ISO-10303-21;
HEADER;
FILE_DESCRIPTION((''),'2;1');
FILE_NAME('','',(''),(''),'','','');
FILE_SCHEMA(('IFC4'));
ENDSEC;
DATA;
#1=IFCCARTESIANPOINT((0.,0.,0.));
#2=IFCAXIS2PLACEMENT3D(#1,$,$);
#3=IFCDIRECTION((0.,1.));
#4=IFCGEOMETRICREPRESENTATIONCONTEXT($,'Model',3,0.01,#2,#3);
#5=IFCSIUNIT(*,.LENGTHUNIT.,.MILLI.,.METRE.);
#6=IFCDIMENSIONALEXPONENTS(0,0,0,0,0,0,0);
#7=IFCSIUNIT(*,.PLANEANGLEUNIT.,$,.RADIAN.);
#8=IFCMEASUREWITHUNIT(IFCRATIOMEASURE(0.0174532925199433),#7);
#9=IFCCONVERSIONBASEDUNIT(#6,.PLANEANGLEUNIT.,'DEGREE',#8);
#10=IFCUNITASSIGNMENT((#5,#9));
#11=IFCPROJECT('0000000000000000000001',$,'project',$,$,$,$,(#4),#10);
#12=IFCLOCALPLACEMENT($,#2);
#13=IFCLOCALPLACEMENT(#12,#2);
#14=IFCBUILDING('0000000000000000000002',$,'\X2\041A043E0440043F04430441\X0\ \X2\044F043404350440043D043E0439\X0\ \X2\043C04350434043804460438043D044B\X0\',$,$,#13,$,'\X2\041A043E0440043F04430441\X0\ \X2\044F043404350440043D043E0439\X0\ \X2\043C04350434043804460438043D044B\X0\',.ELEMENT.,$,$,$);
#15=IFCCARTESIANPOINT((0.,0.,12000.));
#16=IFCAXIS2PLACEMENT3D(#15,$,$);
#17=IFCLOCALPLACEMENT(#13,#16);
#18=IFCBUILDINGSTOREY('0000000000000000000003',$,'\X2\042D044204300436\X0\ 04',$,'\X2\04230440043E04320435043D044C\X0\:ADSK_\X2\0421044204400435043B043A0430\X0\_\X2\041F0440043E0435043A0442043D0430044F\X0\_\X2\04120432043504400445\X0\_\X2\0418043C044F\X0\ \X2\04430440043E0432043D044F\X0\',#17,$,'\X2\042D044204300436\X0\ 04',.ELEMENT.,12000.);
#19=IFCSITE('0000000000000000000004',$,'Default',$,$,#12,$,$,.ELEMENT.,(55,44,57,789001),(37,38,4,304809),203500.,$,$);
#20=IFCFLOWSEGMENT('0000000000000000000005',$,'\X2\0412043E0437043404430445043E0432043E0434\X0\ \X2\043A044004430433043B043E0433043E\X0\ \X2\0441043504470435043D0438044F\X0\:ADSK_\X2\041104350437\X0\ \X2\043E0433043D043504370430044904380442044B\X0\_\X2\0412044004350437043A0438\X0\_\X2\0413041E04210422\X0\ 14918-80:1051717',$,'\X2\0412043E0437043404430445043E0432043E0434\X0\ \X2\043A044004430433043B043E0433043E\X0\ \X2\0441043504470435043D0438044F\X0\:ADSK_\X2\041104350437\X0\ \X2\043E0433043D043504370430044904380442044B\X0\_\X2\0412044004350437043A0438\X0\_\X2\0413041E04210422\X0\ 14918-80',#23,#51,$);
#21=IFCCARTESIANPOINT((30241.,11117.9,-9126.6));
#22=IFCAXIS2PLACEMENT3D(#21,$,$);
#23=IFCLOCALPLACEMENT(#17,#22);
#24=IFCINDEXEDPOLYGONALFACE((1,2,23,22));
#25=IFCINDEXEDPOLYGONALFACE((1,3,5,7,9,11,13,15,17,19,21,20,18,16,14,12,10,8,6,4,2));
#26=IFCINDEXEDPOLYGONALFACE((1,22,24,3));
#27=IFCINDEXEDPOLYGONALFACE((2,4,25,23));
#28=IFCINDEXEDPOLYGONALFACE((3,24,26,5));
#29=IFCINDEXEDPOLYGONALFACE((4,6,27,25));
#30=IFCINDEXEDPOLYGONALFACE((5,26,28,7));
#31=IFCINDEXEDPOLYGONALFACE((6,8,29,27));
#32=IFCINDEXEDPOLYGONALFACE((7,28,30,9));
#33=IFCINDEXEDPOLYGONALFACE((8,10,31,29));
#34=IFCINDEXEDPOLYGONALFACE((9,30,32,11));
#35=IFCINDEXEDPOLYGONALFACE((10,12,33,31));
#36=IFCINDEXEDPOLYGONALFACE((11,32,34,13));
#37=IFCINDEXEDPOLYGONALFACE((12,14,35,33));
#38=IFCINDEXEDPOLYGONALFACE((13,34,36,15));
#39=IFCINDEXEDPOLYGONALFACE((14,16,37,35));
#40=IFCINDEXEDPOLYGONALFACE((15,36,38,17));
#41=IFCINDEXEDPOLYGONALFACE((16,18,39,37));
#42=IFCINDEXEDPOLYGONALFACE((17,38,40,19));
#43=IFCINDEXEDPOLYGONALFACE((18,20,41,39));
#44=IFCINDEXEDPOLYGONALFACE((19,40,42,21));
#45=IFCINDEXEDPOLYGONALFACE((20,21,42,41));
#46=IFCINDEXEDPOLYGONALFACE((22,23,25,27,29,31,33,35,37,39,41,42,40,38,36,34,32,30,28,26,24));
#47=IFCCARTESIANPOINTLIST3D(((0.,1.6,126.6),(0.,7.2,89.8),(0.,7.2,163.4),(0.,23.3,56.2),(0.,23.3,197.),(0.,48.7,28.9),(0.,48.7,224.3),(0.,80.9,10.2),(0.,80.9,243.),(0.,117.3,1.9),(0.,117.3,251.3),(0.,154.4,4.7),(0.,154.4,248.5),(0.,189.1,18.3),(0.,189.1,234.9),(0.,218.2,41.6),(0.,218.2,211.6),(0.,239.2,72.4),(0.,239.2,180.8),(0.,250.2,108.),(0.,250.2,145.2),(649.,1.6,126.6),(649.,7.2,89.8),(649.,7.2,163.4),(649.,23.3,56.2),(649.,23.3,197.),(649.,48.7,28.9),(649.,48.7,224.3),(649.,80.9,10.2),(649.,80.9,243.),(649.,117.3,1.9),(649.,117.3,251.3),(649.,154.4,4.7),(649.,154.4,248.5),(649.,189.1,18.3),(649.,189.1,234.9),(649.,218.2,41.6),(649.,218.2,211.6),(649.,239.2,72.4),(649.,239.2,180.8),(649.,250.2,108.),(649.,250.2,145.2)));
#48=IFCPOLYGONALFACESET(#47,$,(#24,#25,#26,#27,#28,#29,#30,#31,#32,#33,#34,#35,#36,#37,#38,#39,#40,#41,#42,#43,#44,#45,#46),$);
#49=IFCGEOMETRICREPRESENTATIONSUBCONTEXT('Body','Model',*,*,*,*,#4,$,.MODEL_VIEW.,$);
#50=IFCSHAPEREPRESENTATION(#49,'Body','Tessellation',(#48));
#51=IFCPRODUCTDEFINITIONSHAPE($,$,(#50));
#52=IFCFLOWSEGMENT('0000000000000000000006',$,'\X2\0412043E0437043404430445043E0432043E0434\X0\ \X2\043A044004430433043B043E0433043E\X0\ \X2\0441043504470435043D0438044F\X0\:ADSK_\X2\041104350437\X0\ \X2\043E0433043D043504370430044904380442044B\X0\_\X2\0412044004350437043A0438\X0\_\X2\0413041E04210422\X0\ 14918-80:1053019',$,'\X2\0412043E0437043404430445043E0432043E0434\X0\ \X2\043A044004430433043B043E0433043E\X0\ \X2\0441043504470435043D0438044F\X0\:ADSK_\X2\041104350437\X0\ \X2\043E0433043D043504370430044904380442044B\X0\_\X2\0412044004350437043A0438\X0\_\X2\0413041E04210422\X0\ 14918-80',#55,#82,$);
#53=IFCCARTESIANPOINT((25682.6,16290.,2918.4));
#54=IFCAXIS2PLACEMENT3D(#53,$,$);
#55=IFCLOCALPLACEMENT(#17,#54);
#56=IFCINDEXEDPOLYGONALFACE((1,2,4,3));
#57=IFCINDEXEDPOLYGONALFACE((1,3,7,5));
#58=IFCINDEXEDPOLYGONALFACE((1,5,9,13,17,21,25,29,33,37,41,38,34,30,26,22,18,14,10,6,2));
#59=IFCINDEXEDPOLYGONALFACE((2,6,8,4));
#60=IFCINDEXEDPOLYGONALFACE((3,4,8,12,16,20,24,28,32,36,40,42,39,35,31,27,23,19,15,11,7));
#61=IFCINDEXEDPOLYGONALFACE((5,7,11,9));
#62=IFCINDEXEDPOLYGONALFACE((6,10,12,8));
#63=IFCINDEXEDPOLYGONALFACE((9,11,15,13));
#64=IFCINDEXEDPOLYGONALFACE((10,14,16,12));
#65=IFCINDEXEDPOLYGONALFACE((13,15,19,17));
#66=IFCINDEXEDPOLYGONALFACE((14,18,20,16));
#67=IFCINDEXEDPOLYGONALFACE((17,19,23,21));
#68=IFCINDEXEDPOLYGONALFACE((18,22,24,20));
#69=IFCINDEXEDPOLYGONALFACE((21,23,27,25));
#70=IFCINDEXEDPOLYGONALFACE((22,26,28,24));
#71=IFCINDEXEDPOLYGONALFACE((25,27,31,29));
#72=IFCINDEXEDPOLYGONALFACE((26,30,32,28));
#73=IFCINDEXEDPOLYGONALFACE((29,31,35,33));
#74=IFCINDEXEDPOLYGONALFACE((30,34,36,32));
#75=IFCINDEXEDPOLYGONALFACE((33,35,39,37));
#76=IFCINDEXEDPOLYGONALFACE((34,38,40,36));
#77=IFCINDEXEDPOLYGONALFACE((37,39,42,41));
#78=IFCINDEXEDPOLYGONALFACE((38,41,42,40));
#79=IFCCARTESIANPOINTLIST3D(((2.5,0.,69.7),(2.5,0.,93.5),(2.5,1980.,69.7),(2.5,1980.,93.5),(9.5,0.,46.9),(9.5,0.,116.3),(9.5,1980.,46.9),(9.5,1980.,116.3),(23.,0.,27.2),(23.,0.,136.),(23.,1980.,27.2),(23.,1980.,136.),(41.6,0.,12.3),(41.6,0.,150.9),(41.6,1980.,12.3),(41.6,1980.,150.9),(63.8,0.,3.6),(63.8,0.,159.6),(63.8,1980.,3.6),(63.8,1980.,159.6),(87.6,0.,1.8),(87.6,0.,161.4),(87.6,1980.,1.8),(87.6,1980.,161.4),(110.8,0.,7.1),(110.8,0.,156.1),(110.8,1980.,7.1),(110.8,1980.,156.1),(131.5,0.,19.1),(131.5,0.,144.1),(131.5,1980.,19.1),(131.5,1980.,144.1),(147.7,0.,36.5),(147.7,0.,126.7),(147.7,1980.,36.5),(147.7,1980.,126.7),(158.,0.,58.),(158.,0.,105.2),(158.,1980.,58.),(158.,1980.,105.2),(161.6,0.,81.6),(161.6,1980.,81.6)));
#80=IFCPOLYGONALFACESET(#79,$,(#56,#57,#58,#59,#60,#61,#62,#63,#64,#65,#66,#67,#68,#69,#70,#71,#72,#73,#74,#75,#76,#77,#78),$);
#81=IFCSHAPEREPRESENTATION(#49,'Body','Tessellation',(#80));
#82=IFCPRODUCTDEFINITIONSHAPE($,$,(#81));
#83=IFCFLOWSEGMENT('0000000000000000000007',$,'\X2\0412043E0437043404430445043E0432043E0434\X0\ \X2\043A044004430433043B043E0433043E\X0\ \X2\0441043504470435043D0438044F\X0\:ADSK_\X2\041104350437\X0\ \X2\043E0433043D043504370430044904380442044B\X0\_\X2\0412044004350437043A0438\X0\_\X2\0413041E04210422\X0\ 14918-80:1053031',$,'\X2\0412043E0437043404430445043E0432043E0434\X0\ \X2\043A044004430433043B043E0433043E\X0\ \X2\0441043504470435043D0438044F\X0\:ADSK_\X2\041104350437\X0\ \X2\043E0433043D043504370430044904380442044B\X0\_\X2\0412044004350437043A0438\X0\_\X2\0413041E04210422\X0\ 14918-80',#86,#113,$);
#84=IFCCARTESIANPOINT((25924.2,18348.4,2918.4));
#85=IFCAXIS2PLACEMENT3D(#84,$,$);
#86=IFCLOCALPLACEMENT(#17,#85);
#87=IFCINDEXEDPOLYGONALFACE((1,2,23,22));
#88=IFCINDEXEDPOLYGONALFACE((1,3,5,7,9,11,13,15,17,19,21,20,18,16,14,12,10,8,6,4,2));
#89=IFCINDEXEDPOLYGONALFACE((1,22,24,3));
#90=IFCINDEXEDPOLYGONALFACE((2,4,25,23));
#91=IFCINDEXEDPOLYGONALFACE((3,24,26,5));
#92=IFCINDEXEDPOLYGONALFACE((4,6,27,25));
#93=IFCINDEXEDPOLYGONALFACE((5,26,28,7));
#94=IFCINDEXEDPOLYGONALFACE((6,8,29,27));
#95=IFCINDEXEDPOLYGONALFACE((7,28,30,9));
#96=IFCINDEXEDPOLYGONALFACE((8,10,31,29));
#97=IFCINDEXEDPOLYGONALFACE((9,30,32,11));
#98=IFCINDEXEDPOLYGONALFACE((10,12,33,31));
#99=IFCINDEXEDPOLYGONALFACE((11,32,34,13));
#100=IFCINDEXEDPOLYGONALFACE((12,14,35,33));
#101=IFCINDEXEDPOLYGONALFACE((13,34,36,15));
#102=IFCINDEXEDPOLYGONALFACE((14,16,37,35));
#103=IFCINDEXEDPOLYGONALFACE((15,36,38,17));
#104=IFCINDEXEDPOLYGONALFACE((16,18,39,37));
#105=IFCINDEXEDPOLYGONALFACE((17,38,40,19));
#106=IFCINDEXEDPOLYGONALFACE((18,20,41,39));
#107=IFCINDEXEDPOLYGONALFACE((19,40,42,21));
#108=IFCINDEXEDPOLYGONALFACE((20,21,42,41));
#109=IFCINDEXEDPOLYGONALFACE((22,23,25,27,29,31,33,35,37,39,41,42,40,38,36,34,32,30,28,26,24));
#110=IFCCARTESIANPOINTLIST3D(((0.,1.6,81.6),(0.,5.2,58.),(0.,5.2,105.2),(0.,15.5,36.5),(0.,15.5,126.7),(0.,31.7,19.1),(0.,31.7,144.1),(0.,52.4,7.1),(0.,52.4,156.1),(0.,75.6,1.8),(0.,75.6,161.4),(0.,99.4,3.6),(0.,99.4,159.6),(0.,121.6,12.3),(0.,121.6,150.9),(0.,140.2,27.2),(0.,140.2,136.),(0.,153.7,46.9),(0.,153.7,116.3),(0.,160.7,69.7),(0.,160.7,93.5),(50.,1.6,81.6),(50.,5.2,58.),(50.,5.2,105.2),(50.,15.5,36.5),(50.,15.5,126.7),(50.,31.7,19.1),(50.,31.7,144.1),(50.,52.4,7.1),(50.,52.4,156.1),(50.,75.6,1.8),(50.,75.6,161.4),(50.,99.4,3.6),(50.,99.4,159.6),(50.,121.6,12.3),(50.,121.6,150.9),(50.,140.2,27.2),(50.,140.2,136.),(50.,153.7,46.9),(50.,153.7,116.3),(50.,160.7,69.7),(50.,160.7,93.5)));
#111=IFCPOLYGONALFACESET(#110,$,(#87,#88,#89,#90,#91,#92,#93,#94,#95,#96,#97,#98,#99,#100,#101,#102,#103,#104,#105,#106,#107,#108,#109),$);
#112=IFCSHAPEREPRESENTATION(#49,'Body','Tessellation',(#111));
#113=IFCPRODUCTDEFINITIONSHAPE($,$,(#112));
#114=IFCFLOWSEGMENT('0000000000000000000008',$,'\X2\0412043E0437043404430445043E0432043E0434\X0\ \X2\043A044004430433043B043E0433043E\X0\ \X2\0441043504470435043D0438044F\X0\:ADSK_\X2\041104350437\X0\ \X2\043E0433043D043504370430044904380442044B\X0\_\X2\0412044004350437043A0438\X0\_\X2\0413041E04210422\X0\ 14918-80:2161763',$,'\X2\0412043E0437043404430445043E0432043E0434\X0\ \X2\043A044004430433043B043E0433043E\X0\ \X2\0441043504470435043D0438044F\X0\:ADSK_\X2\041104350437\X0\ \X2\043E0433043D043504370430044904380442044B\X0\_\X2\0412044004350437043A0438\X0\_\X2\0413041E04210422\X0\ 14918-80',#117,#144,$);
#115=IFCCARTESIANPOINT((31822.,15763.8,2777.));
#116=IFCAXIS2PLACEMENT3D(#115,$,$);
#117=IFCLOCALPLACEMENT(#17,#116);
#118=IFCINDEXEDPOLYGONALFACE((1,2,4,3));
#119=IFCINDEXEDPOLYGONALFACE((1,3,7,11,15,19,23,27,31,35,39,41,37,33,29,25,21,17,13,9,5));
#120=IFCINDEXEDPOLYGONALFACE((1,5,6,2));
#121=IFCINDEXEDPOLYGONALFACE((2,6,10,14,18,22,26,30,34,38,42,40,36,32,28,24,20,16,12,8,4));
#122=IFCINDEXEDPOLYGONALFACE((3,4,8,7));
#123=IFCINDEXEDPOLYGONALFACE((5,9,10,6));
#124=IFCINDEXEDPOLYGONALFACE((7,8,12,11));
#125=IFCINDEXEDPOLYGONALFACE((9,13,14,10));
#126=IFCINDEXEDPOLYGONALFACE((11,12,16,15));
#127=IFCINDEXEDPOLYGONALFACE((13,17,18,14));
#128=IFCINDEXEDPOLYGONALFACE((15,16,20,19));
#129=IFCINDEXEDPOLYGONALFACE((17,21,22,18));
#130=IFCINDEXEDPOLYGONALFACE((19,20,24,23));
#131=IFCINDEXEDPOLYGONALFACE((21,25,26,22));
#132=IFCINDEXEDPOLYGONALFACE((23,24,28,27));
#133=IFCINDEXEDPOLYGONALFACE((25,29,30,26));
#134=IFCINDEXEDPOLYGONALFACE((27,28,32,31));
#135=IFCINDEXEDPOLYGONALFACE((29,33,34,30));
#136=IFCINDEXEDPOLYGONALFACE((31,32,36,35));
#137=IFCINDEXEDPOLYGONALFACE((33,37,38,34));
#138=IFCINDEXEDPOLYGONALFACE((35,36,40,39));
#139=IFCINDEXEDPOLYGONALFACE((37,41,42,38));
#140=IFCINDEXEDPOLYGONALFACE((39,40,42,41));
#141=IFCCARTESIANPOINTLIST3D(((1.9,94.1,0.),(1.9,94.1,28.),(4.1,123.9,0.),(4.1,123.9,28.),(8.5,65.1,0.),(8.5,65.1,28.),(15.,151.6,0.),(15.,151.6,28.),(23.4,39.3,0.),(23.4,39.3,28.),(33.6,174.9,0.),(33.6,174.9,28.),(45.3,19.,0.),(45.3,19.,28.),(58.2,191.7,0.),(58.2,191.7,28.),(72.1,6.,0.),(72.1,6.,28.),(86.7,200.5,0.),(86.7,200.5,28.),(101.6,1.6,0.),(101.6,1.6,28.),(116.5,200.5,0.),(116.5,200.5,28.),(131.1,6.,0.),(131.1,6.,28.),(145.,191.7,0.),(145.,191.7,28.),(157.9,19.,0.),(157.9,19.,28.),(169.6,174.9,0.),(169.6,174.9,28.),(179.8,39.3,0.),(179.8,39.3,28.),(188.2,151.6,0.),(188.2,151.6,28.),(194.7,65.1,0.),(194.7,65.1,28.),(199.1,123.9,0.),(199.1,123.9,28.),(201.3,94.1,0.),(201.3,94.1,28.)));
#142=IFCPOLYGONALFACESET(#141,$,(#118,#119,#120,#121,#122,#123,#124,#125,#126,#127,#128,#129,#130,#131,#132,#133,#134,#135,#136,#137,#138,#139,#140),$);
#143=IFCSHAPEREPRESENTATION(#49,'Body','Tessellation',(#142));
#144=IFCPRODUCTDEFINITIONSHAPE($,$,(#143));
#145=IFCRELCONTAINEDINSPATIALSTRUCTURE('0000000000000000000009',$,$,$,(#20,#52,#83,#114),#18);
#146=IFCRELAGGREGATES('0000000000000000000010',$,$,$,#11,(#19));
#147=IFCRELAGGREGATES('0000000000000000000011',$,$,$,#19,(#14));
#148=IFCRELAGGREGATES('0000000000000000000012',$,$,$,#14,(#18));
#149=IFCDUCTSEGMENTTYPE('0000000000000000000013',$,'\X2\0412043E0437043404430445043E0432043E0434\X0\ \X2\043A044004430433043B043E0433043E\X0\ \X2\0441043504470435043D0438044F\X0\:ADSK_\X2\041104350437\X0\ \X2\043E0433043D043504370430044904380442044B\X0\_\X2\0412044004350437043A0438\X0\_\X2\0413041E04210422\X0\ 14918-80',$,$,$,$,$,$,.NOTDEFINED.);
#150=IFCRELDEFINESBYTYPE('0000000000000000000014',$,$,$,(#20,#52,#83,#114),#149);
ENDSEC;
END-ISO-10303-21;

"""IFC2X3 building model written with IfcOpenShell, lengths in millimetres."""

from ifc_helpers import new_model, entity, si_unit, converted_unit, direction, frame, origin, origin_2d_with_axis, place, context, subcontext, project, spatial, circle, extrude, type_object, element, save


model = new_model("IFC2X3")

# Units and contexts
model_context = context("Model", 3, precision=0.01, world=origin(), true_north=direction((0.0, 1.0)))
body_context = subcontext(model_context, "Body", "Model", "MODEL_VIEW")
ifc_project = project(units=[si_unit("LENGTHUNIT", "METRE", prefix="MILLI"), converted_unit("PLANEANGLEUNIT", "DEGREE", entity("IfcRatioMeasure", 0.0174532925199433), si_unit("PLANEANGLEUNIT", "RADIAN"), dimensions=[0, 0, 0, 0, 0, 0, 0])], contexts=[model_context])

# Site, building, storey
site_placement = place(None, origin())
site = spatial("IfcSite", under=ifc_project, at=site_placement, Name="Default", CompositionType="ELEMENT", RefLatitude=(55, 44, 57, 789001), RefLongitude=(37, 38, 4, 304809), RefElevation=203500.0)
building_placement = place(site_placement, origin())
building = spatial("IfcBuilding", under=site, at=building_placement, Name="Корпус ядерной медицины", LongName="Корпус ядерной медицины", CompositionType="ELEMENT")
storey_placement = place(building_placement, frame((0.0, 0.0, 12000.0)))
storey = spatial("IfcBuildingStorey", under=building, at=storey_placement, Name="Этаж 04", ObjectType="Уровень:ADSK_Стрелка_Проектная_Вверх_Имя уровня", LongName="Этаж 04", CompositionType="ELEMENT", Elevation=12000.0)

# Flow segments
duct_segment_type = type_object("IfcDuctSegmentType", Name="Воздуховод круглого сечения:ADSK_Без огнезащиты_Врезки_ГОСТ 14918-80", PredefinedType="NOTDEFINED")
flow_segment_1_placement = place(storey_placement, frame((30241.0, 11117.9, -9126.6)))
element("IfcFlowSegment", 1, at=flow_segment_1_placement, inside=storey, type_object=duct_segment_type, Name="Воздуховод круглого сечения:ADSK_Без огнезащиты_Врезки_ГОСТ 14918-80:1051717", ObjectType="Воздуховод круглого сечения:ADSK_Без огнезащиты_Врезки_ГОСТ 14918-80", context=body_context, shape_type="SweptSolid", body=[
    extrude(circle(Radius=125.0, at=origin_2d_with_axis()), frame((0.0, 126.6, 126.6), z_axis=(1.0, 0.0, 0.0), x_axis=(0.0, -1.0, 0.0)), (0.0, 0.0, 1.0), 649.0),
])
flow_segment_2_placement = place(storey_placement, frame((25682.6, 16290.0, 2918.4)))
element("IfcFlowSegment", 2, at=flow_segment_2_placement, inside=storey, type_object=duct_segment_type, Name="Воздуховод круглого сечения:ADSK_Без огнезащиты_Врезки_ГОСТ 14918-80:1053019", ObjectType="Воздуховод круглого сечения:ADSK_Без огнезащиты_Врезки_ГОСТ 14918-80", context=body_context, shape_type="SweptSolid", body=[
    extrude(circle(Radius=80.0, at=origin_2d_with_axis()), frame((81.6, 0.0, 81.6), z_axis=(0.0, 1.0, 0.0), x_axis=(1.0, 0.0, 0.0)), (0.0, 0.0, 1.0), 1980.0),
])
flow_segment_3_placement = place(storey_placement, frame((25924.2, 18348.4, 2918.4)))
element("IfcFlowSegment", 3, at=flow_segment_3_placement, inside=storey, type_object=duct_segment_type, Name="Воздуховод круглого сечения:ADSK_Без огнезащиты_Врезки_ГОСТ 14918-80:1053031", ObjectType="Воздуховод круглого сечения:ADSK_Без огнезащиты_Врезки_ГОСТ 14918-80", context=body_context, shape_type="SweptSolid", body=[
    extrude(circle(Radius=80.0, at=origin_2d_with_axis()), frame((0.0, 81.6, 81.6), z_axis=(1.0, 0.0, 0.0), x_axis=(0.0, -1.0, 0.0)), (0.0, 0.0, 1.0), 50.0),
])
flow_segment_4_placement = place(storey_placement, frame((31822.0, 15763.8, 2777.0)))
element("IfcFlowSegment", 4, at=flow_segment_4_placement, inside=storey, type_object=duct_segment_type, Name="Воздуховод круглого сечения:ADSK_Без огнезащиты_Врезки_ГОСТ 14918-80:2161763", ObjectType="Воздуховод круглого сечения:ADSK_Без огнезащиты_Врезки_ГОСТ 14918-80", context=body_context, shape_type="SweptSolid", body=[
    extrude(circle(Radius=100.0, at=origin_2d_with_axis()), frame((101.6, 101.6, 0.0), z_axis=(0.0, 0.0, 1.0), x_axis=(0.0, -1.0, 0.0)), (0.0, 0.0, 1.0), 28.0),
])

save(model, "model.ifc")
